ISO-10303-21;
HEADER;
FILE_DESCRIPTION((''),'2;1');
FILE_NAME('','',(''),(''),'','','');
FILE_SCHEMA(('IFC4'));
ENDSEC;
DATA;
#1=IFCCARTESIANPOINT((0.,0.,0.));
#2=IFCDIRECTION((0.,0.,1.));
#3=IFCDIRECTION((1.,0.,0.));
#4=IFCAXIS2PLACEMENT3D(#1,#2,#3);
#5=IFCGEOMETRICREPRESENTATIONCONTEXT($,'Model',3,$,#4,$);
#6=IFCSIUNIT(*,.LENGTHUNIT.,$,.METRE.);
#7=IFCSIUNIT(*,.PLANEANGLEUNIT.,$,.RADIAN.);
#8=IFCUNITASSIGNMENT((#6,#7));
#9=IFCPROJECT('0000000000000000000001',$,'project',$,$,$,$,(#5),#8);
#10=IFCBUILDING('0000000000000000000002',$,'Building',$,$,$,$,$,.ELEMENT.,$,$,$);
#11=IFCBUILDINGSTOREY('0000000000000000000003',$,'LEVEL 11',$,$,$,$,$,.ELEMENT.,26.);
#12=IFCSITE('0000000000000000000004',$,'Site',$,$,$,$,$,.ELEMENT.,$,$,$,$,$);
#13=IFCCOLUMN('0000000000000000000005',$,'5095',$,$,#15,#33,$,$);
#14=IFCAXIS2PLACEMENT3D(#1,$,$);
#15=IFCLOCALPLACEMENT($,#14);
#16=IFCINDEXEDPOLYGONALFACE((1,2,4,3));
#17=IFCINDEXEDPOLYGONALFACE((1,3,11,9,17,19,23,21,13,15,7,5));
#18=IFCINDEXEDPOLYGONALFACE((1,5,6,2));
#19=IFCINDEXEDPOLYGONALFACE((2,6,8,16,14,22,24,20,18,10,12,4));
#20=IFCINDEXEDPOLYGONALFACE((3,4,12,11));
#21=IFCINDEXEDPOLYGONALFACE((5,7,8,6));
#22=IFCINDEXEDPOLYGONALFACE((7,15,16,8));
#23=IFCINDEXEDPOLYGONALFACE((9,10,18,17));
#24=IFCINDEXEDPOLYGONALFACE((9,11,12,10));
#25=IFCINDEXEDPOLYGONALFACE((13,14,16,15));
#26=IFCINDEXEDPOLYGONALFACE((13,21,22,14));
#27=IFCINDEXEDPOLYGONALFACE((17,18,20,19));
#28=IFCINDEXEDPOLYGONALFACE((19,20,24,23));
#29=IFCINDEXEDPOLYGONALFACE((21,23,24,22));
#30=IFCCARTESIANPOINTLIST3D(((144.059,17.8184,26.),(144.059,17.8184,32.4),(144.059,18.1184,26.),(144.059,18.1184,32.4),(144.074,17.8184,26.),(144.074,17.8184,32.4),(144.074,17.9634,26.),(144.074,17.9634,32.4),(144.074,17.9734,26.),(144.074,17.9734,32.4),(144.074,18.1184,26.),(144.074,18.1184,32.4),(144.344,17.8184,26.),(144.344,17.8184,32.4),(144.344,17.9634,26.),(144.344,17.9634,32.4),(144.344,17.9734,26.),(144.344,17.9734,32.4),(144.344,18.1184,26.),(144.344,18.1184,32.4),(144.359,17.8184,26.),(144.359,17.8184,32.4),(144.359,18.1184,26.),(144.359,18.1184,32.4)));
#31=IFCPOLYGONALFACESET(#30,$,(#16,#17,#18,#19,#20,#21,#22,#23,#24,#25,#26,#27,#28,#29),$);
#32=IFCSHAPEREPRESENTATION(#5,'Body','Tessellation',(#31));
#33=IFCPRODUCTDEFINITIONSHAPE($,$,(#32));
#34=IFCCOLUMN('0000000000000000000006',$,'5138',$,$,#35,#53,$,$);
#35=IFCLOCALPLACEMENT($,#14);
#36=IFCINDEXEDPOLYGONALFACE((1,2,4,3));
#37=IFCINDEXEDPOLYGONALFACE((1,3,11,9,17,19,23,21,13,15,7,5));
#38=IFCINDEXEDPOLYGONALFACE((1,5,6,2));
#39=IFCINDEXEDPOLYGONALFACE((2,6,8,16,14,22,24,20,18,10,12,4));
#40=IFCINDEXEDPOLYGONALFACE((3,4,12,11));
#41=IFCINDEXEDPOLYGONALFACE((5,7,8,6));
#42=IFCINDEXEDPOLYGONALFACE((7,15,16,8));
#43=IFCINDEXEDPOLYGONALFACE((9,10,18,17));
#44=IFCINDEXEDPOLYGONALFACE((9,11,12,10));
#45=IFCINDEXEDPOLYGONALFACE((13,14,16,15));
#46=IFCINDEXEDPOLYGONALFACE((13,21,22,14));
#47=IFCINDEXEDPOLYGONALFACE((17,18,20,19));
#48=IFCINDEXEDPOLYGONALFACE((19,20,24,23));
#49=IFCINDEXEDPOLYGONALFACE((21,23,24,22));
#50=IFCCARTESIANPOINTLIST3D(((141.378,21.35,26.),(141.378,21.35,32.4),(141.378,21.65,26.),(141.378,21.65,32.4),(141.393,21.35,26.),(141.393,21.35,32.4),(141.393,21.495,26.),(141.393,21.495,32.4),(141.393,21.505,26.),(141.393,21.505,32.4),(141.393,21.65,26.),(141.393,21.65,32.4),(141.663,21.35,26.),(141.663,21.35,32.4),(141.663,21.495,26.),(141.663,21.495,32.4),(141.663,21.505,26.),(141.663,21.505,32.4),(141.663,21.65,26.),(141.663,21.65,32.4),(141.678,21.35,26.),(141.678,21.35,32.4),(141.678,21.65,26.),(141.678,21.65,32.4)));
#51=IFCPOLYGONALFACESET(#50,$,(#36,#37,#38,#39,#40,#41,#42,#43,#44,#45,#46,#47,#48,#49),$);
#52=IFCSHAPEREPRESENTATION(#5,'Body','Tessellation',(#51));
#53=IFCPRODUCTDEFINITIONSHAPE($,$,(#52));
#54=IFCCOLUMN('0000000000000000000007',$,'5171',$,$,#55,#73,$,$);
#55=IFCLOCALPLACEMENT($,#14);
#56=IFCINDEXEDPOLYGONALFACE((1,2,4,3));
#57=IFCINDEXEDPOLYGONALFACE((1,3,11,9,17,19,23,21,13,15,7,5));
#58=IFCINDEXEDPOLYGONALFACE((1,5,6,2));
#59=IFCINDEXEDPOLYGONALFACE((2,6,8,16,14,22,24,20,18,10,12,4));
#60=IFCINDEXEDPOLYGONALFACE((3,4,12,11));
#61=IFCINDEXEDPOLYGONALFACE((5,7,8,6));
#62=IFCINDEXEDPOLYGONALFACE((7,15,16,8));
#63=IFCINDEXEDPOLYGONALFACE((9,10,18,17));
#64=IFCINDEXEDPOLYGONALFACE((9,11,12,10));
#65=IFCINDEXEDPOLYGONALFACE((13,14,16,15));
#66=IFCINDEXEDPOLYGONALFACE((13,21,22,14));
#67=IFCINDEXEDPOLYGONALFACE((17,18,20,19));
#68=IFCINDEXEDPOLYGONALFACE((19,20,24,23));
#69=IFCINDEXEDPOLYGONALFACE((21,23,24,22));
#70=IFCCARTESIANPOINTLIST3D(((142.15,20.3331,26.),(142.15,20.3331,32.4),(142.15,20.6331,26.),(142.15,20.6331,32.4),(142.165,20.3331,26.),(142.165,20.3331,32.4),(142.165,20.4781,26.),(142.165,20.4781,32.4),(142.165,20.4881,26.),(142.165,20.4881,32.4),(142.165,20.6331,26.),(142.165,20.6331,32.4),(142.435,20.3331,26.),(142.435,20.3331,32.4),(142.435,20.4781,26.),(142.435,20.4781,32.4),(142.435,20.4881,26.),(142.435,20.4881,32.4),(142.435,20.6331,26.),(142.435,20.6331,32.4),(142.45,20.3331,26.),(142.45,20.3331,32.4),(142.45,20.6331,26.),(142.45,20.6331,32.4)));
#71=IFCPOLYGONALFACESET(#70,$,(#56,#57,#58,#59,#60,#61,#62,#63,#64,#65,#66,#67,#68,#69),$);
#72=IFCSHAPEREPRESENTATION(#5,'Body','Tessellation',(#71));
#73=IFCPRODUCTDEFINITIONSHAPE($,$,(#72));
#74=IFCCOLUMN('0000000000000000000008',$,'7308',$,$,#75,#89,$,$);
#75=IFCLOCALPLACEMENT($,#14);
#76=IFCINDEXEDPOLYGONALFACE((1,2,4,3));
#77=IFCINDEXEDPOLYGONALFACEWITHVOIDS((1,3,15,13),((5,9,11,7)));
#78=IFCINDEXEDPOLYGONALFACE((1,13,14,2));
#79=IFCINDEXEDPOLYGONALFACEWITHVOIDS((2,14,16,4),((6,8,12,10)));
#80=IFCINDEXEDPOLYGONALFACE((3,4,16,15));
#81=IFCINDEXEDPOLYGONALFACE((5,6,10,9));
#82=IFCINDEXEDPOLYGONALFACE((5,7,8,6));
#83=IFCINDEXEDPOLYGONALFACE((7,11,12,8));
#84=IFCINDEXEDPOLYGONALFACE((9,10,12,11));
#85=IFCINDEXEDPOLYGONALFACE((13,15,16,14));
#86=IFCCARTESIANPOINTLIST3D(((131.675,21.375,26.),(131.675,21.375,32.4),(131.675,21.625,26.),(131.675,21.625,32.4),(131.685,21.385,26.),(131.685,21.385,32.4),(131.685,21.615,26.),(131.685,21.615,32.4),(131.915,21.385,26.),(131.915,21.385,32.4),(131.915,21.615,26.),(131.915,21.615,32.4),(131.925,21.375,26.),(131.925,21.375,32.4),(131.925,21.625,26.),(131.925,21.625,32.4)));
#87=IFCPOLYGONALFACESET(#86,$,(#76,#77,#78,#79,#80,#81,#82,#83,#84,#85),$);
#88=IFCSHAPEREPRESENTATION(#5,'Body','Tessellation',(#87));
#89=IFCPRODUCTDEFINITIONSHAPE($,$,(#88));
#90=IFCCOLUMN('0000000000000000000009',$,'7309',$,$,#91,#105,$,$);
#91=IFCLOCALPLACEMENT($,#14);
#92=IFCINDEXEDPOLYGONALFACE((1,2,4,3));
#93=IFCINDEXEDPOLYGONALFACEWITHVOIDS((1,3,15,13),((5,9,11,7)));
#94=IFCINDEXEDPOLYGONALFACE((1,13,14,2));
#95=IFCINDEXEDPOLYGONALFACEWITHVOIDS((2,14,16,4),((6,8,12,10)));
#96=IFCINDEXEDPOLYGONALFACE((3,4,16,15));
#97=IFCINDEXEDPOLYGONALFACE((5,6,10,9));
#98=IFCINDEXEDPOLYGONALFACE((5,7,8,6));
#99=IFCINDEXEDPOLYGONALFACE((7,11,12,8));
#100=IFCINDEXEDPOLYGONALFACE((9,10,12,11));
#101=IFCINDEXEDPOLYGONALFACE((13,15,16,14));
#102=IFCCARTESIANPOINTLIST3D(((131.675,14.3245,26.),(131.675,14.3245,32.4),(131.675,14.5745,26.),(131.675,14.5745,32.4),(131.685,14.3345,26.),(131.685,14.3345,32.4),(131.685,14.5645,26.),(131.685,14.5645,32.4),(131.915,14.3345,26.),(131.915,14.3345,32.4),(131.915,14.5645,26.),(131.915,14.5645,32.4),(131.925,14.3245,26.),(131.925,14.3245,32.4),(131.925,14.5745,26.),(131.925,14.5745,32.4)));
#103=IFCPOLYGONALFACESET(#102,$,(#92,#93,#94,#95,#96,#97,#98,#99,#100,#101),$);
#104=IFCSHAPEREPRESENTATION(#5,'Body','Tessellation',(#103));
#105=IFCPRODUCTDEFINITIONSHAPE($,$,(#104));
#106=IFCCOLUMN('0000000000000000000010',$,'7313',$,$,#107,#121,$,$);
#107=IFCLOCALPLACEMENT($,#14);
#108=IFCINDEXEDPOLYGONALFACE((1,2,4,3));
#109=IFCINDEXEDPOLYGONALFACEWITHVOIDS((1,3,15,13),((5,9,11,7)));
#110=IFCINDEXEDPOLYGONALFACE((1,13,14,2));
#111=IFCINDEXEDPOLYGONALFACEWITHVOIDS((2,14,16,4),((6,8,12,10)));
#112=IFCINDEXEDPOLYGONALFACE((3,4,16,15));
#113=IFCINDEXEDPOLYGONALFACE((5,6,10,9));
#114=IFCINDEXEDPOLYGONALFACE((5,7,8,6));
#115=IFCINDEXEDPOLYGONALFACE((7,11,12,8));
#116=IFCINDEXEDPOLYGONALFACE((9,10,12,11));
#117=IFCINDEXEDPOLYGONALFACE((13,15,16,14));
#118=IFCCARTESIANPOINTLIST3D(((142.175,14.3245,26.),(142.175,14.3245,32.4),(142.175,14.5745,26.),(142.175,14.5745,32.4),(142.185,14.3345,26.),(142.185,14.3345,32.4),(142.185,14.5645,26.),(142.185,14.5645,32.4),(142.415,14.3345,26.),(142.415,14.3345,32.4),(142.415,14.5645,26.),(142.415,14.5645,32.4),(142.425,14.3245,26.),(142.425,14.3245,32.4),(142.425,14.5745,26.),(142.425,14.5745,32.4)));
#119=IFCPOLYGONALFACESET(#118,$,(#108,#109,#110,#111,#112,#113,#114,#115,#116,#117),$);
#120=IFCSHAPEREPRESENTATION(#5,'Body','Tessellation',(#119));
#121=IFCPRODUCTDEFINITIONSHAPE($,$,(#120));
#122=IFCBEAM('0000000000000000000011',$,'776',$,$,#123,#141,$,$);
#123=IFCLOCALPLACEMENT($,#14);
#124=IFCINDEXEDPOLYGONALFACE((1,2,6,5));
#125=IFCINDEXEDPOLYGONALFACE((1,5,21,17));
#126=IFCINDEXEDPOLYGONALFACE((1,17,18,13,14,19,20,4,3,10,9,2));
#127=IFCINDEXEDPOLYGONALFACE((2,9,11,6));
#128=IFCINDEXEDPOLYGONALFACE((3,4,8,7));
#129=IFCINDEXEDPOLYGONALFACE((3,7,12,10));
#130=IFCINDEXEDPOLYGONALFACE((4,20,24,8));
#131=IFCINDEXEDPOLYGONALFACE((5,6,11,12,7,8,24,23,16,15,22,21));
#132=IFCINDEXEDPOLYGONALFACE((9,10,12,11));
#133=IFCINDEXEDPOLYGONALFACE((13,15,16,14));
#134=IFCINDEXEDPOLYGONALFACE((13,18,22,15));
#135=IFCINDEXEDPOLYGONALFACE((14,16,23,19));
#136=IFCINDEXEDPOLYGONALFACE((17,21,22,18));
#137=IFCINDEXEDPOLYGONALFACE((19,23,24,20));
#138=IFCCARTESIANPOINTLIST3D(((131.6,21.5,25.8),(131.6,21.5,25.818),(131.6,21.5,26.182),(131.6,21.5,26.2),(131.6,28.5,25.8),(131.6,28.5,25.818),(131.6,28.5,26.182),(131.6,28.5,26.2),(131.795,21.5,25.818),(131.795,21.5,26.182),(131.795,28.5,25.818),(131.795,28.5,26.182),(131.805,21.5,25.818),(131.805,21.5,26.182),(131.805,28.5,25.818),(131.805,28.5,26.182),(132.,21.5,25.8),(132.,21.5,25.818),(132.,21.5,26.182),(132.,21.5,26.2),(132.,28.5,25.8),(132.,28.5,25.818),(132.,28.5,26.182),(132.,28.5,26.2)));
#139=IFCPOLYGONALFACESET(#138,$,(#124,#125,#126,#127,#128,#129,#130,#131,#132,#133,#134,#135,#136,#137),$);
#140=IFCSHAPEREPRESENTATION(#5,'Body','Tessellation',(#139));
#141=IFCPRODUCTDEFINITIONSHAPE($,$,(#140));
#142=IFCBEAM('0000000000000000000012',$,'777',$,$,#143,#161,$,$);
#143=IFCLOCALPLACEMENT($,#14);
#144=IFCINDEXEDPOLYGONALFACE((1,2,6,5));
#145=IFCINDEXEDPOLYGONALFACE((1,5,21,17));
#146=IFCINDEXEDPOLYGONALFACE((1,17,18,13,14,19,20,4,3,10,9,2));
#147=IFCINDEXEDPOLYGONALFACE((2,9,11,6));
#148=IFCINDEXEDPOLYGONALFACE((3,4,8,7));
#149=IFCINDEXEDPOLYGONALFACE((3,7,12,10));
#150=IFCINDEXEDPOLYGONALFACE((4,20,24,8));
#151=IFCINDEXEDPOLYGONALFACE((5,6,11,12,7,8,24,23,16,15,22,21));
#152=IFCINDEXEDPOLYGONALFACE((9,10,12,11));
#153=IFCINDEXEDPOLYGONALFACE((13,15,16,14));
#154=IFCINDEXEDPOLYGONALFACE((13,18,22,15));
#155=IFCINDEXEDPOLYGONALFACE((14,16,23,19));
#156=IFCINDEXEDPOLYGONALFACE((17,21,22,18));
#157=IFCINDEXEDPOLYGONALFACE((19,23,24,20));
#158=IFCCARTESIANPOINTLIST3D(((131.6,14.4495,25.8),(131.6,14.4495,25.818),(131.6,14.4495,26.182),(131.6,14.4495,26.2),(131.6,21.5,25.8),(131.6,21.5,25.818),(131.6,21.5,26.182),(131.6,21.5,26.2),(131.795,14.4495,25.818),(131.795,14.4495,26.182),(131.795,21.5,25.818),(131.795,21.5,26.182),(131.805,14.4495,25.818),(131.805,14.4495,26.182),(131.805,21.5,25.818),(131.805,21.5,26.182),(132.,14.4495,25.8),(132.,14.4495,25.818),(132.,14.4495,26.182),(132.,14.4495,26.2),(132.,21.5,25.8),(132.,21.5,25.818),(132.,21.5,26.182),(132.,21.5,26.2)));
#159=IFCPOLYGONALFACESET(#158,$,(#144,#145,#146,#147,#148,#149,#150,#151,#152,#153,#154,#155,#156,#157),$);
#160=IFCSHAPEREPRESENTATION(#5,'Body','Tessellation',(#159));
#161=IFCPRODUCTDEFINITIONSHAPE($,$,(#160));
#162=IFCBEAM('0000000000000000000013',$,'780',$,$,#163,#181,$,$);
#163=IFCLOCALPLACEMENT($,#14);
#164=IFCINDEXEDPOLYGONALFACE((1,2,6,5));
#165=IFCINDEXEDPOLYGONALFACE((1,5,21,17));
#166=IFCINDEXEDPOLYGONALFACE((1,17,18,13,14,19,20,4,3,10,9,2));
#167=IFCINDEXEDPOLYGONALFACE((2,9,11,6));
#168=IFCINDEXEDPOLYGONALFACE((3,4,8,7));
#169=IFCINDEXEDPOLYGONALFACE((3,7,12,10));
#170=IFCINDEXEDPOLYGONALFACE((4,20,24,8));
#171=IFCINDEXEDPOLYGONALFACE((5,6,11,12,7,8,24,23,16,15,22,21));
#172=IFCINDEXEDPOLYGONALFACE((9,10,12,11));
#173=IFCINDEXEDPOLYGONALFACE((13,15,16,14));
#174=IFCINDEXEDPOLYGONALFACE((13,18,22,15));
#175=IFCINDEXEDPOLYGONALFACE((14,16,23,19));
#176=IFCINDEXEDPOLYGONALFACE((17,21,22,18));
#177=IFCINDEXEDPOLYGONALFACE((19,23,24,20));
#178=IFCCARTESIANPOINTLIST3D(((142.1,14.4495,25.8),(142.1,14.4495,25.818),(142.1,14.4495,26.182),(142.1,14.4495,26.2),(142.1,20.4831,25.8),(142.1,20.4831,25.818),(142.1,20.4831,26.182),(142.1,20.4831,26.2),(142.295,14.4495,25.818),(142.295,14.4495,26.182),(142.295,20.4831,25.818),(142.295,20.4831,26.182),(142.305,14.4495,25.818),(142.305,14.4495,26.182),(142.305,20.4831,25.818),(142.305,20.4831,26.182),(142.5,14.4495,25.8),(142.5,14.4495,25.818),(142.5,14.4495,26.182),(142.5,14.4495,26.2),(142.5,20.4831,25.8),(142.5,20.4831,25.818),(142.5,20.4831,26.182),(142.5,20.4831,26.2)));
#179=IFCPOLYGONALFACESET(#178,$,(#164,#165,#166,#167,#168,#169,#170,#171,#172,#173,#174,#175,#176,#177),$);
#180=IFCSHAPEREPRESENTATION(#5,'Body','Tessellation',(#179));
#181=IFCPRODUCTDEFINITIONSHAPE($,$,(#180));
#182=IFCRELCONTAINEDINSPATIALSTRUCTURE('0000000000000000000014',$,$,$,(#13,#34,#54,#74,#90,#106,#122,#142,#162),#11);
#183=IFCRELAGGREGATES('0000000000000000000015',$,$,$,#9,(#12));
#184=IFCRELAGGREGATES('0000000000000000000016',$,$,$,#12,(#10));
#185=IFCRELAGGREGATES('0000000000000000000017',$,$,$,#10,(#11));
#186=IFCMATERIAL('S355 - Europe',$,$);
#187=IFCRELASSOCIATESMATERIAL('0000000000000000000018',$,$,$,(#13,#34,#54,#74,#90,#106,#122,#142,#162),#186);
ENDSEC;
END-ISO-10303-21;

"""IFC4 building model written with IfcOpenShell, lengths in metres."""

from ifc_helpers import new_model, si_unit, frame, origin_with_axes, origin_2d_with_axis, place, context, project, spatial, hollow_rectangle, i_section, extrude, material, material_profile, profile_set, profile_usage, element, save


model = new_model("IFC4")

# Units and contexts
model_context = context("Model", 3, world=origin_with_axes())
ifc_project = project(units=[si_unit("LENGTHUNIT", "METRE"), si_unit("PLANEANGLEUNIT", "RADIAN")], contexts=[model_context])

# Site, building, storey
site = spatial("IfcSite", under=ifc_project, Name="Site", CompositionType="ELEMENT")
building = spatial("IfcBuilding", under=site, Name="Building", CompositionType="ELEMENT")
storey = spatial("IfcBuildingStorey", under=building, Name="LEVEL 11", CompositionType="ELEMENT", Elevation=26.0)

# Columns
ifc_material = material(Name="S355 - Europe")
ifc_material_profile_1 = material_profile(ifc_material, i_section(OverallWidth=0.3, OverallDepth=0.3, WebThickness=0.01, FlangeThickness=0.015, at=origin_2d_with_axis()))
ifc_profile_set_1 = profile_set([ifc_material_profile_1])
ifc_profile_usage_1 = profile_usage(ifc_profile_set_1, cardinal=10)
column_1_placement = place(None, frame((144.209, 17.9684, 26.0), z_axis=(0.0, 0.0, 1.0), x_axis=(0.0, -1.0, 0.0)))
element("IfcColumn", 1, at=column_1_placement, inside=storey, material=ifc_profile_usage_1, Name="5095", context=model_context, shape_type="SweptSolid", body=[
    extrude(i_section(OverallWidth=0.3, OverallDepth=0.3, WebThickness=0.01, FlangeThickness=0.015, at=origin_2d_with_axis()), origin_with_axes(), (0.0, 0.0, 1.0), 6.4),
])
ifc_material_profile_2 = material_profile(ifc_material, i_section(OverallWidth=0.3, OverallDepth=0.3, WebThickness=0.01, FlangeThickness=0.015, at=origin_2d_with_axis()))
ifc_profile_set_2 = profile_set([ifc_material_profile_2])
ifc_profile_usage_2 = profile_usage(ifc_profile_set_2, cardinal=10)
column_2_placement = place(None, frame((141.528, 21.5, 26.0), z_axis=(0.0, 0.0, 1.0), x_axis=(0.0, -1.0, 0.0)))
element("IfcColumn", 2, at=column_2_placement, inside=storey, material=ifc_profile_usage_2, Name="5138", context=model_context, shape_type="SweptSolid", body=[
    extrude(i_section(OverallWidth=0.3, OverallDepth=0.3, WebThickness=0.01, FlangeThickness=0.015, at=origin_2d_with_axis()), origin_with_axes(), (0.0, 0.0, 1.0), 6.4),
])
ifc_material_profile_3 = material_profile(ifc_material, i_section(OverallWidth=0.3, OverallDepth=0.3, WebThickness=0.01, FlangeThickness=0.015, at=origin_2d_with_axis()))
ifc_profile_set_3 = profile_set([ifc_material_profile_3])
ifc_profile_usage_3 = profile_usage(ifc_profile_set_3, cardinal=10)
column_3_placement = place(None, frame((142.3, 20.4831, 26.0), z_axis=(0.0, 0.0, 1.0), x_axis=(0.0, -1.0, 0.0)))
element("IfcColumn", 3, at=column_3_placement, inside=storey, material=ifc_profile_usage_3, Name="5171", context=model_context, shape_type="SweptSolid", body=[
    extrude(i_section(OverallWidth=0.3, OverallDepth=0.3, WebThickness=0.01, FlangeThickness=0.015, at=origin_2d_with_axis()), origin_with_axes(), (0.0, 0.0, 1.0), 6.4),
])
ifc_material_profile_4 = material_profile(ifc_material, hollow_rectangle(XDim=0.25, YDim=0.25, WallThickness=0.01, at=origin_2d_with_axis()))
ifc_profile_set_4 = profile_set([ifc_material_profile_4])
ifc_profile_usage_4 = profile_usage(ifc_profile_set_4, cardinal=10)
column_4_placement = place(None, frame((131.8, 21.5, 26.0), z_axis=(0.0, 0.0, 1.0), x_axis=(0.0, -1.0, 0.0)))
element("IfcColumn", 4, at=column_4_placement, inside=storey, material=ifc_profile_usage_4, Name="7308", context=model_context, shape_type="SweptSolid", body=[
    extrude(hollow_rectangle(XDim=0.25, YDim=0.25, WallThickness=0.01, at=origin_2d_with_axis()), origin_with_axes(), (0.0, 0.0, 1.0), 6.4),
])
ifc_material_profile_5 = material_profile(ifc_material, hollow_rectangle(XDim=0.25, YDim=0.25, WallThickness=0.01, at=origin_2d_with_axis()))
ifc_profile_set_5 = profile_set([ifc_material_profile_5])
ifc_profile_usage_5 = profile_usage(ifc_profile_set_5, cardinal=10)
column_5_placement = place(None, frame((131.8, 14.4495, 26.0), z_axis=(0.0, 0.0, 1.0), x_axis=(0.0, -1.0, 0.0)))
element("IfcColumn", 5, at=column_5_placement, inside=storey, material=ifc_profile_usage_5, Name="7309", context=model_context, shape_type="SweptSolid", body=[
    extrude(hollow_rectangle(XDim=0.25, YDim=0.25, WallThickness=0.01, at=origin_2d_with_axis()), origin_with_axes(), (0.0, 0.0, 1.0), 6.4),
])
ifc_material_profile_6 = material_profile(ifc_material, hollow_rectangle(XDim=0.25, YDim=0.25, WallThickness=0.01, at=origin_2d_with_axis()))
ifc_profile_set_6 = profile_set([ifc_material_profile_6])
ifc_profile_usage_6 = profile_usage(ifc_profile_set_6, cardinal=10)
column_6_placement = place(None, frame((142.3, 14.4495, 26.0), z_axis=(0.0, 0.0, 1.0), x_axis=(0.0, -1.0, 0.0)))
element("IfcColumn", 6, at=column_6_placement, inside=storey, material=ifc_profile_usage_6, Name="7313", context=model_context, shape_type="SweptSolid", body=[
    extrude(hollow_rectangle(XDim=0.25, YDim=0.25, WallThickness=0.01, at=origin_2d_with_axis()), origin_with_axes(), (0.0, 0.0, 1.0), 6.4),
])

# Beams
ifc_material_profile_7 = material_profile(ifc_material, i_section(OverallWidth=0.4, OverallDepth=0.4, WebThickness=0.01, FlangeThickness=0.018, at=origin_2d_with_axis()))
ifc_profile_set_7 = profile_set([ifc_material_profile_7])
ifc_profile_usage_7 = profile_usage(ifc_profile_set_7, cardinal=10)
beam_1_placement = place(None, frame((131.8, 21.5, 26.0), z_axis=(0.0, 1.0, 0.0), x_axis=(-1.0, 0.0, 0.0)))
element("IfcBeam", 7, at=beam_1_placement, inside=storey, material=ifc_profile_usage_7, Name="776", context=model_context, shape_type="SweptSolid", body=[
    extrude(i_section(OverallWidth=0.4, OverallDepth=0.4, WebThickness=0.01, FlangeThickness=0.018, at=origin_2d_with_axis()), origin_with_axes(), (0.0, 0.0, 1.0), 7.0),
])
ifc_material_profile_8 = material_profile(ifc_material, i_section(OverallWidth=0.4, OverallDepth=0.4, WebThickness=0.01, FlangeThickness=0.018, at=origin_2d_with_axis()))
ifc_profile_set_8 = profile_set([ifc_material_profile_8])
ifc_profile_usage_8 = profile_usage(ifc_profile_set_8, cardinal=10)
beam_2_placement = place(None, frame((131.8, 14.4495, 26.0), z_axis=(0.0, 1.0, 0.0), x_axis=(-1.0, 0.0, 0.0)))
element("IfcBeam", 8, at=beam_2_placement, inside=storey, material=ifc_profile_usage_8, Name="777", context=model_context, shape_type="SweptSolid", body=[
    extrude(i_section(OverallWidth=0.4, OverallDepth=0.4, WebThickness=0.01, FlangeThickness=0.018, at=origin_2d_with_axis()), origin_with_axes(), (0.0, 0.0, 1.0), 7.0505),
])
ifc_material_profile_9 = material_profile(ifc_material, i_section(OverallWidth=0.4, OverallDepth=0.4, WebThickness=0.01, FlangeThickness=0.018, at=origin_2d_with_axis()))
ifc_profile_set_9 = profile_set([ifc_material_profile_9])
ifc_profile_usage_9 = profile_usage(ifc_profile_set_9, cardinal=10)
beam_3_placement = place(None, frame((142.3, 20.4831, 26.0), z_axis=(0.0, -1.0, 0.0), x_axis=(1.0, 0.0, 0.0)))
element("IfcBeam", 9, at=beam_3_placement, inside=storey, material=ifc_profile_usage_9, Name="780", context=model_context, shape_type="SweptSolid", body=[
    extrude(i_section(OverallWidth=0.4, OverallDepth=0.4, WebThickness=0.01, FlangeThickness=0.018, at=origin_2d_with_axis()), origin_with_axes(), (0.0, 0.0, 1.0), 6.0336),
])

save(model, "model.ifc")
